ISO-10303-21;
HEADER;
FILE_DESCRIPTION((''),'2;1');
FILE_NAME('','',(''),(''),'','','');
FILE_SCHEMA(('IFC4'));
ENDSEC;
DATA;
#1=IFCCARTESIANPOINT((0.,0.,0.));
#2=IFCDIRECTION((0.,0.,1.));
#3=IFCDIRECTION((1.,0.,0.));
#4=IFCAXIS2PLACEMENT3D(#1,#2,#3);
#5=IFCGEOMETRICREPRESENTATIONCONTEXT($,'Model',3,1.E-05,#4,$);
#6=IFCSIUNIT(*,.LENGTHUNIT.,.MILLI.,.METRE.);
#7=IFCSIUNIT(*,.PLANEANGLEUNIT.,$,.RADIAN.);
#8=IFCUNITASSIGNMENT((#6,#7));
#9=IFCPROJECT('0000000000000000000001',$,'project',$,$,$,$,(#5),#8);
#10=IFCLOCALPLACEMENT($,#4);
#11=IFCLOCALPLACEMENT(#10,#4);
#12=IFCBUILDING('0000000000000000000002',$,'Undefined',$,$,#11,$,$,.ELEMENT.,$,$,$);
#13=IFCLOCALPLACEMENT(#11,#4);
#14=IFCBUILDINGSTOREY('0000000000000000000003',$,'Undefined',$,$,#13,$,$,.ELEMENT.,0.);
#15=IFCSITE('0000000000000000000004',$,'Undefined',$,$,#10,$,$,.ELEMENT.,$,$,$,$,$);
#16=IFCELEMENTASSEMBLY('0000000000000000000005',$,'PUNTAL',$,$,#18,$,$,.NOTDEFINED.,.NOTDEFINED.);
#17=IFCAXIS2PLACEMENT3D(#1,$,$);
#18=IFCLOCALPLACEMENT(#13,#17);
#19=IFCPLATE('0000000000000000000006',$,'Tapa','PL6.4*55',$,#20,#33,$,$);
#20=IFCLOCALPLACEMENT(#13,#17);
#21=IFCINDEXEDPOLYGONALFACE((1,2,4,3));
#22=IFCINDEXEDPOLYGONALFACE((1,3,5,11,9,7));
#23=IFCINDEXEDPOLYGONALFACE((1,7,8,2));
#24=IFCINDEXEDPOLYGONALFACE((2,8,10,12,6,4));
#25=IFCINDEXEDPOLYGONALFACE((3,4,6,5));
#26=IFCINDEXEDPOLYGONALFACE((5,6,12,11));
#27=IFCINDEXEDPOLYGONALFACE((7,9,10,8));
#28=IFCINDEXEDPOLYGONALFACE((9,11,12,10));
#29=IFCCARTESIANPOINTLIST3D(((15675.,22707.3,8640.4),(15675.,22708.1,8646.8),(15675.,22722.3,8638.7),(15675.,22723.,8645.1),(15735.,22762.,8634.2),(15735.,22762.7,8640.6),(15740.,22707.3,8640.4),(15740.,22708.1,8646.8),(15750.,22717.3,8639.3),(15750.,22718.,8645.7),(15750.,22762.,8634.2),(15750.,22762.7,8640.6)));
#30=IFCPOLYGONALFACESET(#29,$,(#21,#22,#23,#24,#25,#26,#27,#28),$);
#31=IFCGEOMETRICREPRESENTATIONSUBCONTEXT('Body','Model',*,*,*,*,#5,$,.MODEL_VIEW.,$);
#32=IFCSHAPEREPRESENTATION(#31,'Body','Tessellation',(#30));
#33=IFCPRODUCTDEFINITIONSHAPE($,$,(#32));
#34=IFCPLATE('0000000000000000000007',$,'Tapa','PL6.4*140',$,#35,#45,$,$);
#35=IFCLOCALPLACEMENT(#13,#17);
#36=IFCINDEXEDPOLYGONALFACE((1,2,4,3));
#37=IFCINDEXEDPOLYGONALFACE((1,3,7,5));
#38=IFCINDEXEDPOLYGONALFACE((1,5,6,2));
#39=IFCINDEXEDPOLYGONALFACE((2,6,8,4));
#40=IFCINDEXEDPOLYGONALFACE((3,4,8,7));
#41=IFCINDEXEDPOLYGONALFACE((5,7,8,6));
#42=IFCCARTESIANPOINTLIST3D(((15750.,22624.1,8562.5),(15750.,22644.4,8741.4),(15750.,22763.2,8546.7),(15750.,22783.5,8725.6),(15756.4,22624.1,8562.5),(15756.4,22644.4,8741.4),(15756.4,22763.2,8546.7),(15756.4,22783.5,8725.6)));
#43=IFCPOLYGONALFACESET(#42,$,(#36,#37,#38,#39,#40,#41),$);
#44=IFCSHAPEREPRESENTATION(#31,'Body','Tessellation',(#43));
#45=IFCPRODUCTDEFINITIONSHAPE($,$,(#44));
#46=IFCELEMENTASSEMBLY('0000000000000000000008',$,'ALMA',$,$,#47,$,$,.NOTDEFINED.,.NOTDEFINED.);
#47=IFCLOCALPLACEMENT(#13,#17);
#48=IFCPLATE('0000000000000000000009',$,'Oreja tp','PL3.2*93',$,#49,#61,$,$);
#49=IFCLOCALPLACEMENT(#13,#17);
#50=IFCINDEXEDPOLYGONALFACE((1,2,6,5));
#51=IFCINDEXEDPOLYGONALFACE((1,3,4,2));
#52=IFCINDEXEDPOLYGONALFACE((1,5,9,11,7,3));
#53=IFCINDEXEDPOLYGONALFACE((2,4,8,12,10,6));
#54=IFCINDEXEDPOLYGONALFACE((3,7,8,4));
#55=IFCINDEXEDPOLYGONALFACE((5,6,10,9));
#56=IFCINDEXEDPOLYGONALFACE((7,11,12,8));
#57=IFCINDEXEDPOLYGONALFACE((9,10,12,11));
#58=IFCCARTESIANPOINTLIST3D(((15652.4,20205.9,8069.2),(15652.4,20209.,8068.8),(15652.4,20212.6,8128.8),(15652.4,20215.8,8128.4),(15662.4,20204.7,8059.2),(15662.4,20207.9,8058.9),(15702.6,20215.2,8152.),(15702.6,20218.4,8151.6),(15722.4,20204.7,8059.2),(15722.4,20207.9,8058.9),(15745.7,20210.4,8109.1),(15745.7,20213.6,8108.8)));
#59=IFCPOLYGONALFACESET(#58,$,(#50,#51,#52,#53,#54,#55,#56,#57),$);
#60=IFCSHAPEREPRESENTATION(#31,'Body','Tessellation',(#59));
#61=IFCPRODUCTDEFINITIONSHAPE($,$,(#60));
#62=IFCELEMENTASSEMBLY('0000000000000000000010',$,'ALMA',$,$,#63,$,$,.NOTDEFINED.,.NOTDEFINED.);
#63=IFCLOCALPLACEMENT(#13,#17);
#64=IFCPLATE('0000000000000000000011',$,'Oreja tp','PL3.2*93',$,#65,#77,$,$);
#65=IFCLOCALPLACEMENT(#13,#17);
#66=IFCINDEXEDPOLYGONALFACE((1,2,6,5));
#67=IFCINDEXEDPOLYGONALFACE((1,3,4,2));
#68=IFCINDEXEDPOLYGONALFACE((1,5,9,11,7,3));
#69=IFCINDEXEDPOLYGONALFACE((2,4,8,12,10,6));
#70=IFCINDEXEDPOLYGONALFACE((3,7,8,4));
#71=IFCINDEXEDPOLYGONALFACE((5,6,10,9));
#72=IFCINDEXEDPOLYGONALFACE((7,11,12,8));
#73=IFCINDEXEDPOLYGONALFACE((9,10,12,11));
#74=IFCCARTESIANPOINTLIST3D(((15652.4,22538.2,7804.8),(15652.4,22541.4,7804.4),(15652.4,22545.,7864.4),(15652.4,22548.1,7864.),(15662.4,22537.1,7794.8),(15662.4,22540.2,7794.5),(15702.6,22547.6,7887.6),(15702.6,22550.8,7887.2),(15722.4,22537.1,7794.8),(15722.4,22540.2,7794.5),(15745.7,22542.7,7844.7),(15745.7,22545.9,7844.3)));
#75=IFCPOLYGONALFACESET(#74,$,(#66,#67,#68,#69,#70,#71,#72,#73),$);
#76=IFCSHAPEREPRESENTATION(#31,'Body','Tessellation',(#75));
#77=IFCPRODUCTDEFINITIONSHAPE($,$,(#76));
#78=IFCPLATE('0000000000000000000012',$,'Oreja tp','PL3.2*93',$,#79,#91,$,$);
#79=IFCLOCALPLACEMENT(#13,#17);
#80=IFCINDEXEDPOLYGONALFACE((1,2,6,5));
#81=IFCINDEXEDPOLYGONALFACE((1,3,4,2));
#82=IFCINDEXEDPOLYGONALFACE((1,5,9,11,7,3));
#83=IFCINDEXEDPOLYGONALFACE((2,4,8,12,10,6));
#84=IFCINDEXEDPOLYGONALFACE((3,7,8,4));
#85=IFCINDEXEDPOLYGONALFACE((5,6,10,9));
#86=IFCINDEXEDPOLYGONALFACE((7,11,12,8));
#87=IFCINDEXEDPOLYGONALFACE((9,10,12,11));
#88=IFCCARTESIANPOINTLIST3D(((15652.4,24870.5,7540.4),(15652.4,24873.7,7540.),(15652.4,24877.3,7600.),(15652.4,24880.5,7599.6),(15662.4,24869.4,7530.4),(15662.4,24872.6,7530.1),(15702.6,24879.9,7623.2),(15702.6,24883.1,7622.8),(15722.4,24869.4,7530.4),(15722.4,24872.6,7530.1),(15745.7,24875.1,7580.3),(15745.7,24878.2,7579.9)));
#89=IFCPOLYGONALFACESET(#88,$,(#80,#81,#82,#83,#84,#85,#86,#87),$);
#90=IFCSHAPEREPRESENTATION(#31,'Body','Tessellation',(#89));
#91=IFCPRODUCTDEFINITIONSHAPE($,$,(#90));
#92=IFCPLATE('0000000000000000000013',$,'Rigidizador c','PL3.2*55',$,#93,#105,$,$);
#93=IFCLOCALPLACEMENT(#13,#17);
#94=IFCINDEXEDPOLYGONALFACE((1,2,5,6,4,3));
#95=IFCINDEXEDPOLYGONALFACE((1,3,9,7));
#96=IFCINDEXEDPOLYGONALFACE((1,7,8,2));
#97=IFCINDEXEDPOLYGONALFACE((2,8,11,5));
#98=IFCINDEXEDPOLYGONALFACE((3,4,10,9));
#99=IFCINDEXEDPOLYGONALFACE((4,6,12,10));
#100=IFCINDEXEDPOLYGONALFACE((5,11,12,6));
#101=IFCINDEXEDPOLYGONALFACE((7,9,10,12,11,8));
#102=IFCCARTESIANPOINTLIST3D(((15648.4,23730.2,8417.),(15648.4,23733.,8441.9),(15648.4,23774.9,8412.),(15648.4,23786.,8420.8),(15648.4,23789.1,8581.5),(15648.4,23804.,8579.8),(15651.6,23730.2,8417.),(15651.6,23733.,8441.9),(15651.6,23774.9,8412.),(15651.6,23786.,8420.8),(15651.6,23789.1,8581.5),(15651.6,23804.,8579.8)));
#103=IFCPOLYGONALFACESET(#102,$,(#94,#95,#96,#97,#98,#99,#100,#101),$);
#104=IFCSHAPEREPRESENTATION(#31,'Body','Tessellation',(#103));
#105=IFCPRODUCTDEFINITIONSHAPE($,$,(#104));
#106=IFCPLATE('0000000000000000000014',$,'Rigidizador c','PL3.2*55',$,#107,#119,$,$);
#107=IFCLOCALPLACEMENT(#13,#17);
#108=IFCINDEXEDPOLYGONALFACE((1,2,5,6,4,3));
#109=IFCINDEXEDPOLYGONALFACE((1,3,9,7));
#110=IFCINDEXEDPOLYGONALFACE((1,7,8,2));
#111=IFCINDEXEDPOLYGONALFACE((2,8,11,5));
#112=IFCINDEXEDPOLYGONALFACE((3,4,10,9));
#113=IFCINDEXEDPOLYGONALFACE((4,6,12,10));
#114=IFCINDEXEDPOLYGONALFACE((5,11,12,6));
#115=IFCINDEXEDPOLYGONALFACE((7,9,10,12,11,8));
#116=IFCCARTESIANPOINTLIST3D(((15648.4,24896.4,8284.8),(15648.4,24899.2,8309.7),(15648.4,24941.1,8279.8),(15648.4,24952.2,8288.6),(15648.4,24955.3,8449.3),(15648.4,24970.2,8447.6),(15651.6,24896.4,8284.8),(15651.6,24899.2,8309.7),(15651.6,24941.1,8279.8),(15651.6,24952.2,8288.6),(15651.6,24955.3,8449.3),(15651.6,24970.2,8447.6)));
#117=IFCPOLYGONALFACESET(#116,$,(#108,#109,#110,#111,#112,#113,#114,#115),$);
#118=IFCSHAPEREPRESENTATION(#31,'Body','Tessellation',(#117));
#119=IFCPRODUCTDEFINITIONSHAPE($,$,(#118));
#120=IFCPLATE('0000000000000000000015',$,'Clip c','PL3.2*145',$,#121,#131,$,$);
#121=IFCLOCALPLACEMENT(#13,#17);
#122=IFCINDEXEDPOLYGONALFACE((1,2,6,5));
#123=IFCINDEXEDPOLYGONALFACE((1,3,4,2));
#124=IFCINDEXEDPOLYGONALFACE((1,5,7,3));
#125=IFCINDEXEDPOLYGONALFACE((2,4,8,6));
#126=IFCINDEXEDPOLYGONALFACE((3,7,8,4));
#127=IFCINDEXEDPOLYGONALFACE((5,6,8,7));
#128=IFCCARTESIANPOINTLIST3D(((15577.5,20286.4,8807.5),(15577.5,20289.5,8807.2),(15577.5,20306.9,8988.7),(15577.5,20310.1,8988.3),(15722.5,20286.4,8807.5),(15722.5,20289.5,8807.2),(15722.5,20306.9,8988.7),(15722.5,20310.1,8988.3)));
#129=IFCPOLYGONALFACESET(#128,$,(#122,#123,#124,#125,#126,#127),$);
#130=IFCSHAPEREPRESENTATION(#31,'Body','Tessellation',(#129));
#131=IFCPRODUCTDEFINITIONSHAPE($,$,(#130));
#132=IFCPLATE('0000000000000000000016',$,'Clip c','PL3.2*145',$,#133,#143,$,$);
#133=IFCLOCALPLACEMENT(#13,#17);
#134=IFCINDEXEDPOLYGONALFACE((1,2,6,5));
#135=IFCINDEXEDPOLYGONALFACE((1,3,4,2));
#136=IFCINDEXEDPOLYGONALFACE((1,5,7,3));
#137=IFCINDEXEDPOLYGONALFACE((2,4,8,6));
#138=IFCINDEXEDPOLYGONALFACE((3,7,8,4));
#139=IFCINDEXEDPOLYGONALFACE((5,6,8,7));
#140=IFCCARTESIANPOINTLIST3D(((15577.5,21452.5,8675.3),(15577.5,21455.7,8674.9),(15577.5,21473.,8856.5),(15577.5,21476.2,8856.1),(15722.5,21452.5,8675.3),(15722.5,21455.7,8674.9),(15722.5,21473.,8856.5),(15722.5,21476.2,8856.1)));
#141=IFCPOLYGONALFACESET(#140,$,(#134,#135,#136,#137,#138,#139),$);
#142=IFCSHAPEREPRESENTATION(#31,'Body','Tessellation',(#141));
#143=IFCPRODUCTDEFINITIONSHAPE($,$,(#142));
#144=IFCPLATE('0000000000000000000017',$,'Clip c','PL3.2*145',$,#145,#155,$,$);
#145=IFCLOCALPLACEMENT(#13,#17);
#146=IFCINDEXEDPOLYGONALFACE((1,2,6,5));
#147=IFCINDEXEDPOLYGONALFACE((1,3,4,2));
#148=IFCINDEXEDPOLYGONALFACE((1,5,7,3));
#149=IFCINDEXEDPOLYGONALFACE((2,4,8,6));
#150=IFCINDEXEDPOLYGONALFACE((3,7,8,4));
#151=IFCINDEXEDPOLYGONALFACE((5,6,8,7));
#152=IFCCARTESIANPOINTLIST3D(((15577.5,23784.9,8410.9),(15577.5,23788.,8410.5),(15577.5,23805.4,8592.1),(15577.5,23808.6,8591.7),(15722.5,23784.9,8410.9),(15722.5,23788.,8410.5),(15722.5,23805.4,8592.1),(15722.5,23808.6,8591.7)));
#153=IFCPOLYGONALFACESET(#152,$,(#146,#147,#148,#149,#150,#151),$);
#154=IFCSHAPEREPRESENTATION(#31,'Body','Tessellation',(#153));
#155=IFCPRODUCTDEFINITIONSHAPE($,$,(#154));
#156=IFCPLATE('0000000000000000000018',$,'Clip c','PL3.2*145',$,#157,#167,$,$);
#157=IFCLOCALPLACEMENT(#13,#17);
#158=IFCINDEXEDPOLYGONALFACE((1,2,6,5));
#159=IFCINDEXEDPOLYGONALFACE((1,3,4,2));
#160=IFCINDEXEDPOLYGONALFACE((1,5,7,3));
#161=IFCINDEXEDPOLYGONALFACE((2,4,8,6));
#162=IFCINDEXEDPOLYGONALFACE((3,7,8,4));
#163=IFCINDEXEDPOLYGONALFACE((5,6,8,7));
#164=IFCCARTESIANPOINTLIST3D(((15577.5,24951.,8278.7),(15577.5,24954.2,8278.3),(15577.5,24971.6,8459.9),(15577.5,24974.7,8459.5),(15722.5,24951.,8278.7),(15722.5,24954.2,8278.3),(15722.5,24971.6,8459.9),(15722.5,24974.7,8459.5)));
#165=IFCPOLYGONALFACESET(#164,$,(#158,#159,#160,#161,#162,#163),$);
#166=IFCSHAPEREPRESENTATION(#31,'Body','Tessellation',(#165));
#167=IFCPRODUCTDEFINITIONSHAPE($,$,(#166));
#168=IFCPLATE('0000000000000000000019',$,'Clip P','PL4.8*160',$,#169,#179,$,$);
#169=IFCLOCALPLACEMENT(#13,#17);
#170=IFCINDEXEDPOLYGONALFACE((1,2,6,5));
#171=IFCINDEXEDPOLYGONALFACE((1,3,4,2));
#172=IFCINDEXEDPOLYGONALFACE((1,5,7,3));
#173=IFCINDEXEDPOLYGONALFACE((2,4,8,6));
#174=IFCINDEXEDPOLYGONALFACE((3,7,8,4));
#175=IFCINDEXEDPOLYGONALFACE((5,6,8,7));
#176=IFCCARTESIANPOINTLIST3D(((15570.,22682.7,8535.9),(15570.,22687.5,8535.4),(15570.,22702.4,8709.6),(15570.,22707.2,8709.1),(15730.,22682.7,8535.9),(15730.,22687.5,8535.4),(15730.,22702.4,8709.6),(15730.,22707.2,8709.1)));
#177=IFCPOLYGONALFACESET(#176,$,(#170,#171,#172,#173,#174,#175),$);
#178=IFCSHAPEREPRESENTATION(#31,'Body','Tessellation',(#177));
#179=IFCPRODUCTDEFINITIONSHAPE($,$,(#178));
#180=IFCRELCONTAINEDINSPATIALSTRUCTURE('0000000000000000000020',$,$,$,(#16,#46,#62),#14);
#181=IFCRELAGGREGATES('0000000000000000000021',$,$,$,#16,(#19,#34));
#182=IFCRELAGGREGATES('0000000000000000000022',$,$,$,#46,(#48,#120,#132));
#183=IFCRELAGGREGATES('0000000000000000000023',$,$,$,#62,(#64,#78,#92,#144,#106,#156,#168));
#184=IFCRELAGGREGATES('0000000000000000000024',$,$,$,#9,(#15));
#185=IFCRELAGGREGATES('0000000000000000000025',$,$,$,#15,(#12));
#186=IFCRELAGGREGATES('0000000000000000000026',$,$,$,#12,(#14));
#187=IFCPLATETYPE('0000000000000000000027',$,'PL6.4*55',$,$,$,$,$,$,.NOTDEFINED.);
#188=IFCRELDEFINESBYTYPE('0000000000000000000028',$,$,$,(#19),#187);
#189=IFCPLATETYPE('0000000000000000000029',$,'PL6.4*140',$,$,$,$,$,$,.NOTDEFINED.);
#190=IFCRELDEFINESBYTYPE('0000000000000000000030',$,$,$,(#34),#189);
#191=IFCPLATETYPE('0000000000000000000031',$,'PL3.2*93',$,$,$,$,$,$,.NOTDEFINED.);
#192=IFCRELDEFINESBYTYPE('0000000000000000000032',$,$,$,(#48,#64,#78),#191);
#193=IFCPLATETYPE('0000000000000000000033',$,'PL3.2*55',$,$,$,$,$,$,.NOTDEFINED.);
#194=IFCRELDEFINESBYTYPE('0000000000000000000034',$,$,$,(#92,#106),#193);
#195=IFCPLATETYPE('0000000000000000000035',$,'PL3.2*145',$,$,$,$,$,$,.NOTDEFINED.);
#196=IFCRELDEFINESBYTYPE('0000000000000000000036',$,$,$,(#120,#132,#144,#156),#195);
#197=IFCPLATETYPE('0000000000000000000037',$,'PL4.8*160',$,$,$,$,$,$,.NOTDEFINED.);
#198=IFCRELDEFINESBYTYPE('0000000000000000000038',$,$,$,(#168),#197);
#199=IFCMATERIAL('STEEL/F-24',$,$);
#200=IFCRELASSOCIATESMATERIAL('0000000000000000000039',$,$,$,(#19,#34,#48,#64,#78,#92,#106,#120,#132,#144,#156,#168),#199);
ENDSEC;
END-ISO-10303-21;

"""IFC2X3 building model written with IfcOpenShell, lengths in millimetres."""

from ifc_helpers import new_model, si_unit, frame, origin_with_axes, place, context, subcontext, project, spatial, polyline, outline, extrude, material, type_object, element, aggregate, save


model = new_model("IFC2X3")

# Units and contexts
model_context = context("Model", 3, precision=1e-05, world=origin_with_axes())
body_context = subcontext(model_context, "Body", "Model", "MODEL_VIEW")
ifc_project = project(units=[si_unit("LENGTHUNIT", "METRE", prefix="MILLI"), si_unit("PLANEANGLEUNIT", "RADIAN")], contexts=[model_context])

# Site, building, storey
site_placement = place(None, origin_with_axes())
site = spatial("IfcSite", under=ifc_project, at=site_placement, Name="Undefined", CompositionType="ELEMENT")
building_placement = place(site_placement, origin_with_axes())
building = spatial("IfcBuilding", under=site, at=building_placement, Name="Undefined", CompositionType="ELEMENT")
storey_placement = place(building_placement, origin_with_axes())
storey = spatial("IfcBuildingStorey", under=building, at=storey_placement, Name="Undefined", CompositionType="ELEMENT", Elevation=0.0)

# Element assembly, plates
assembly_1_placement = place(storey_placement, origin_with_axes())
assembly_1 = element("IfcElementAssembly", 1, at=assembly_1_placement, inside=storey, Name="PUNTAL", AssemblyPlace="NOTDEFINED", PredefinedType="NOTDEFINED")
ifc_material_1 = material(Name="STEEL/F-24")
plate_type_1 = type_object("IfcPlateType", Name="PL6.4*55", PredefinedType="NOTDEFINED")
plate_1_placement = place(assembly_1_placement, frame((15675.0, 22707.7, 8643.6), z_axis=(0.0, 0.112644, 0.993635), x_axis=(1.0, 0.0, 0.0)))
plate_1 = element("IfcPlate", 2, at=plate_1_placement, type_object=plate_type_1, material=ifc_material_1, Name="Tapa", Description="PL6.4*55", context=body_context, shape_type="SweptSolid", body=[
    extrude(outline(polyline([(0.0, 0.0), (65.0, 0.0), (75.0, 10.0), (75.0, 55.0), (60.0, 55.0), (0.0, 15.0), (0.0, 0.0)])), frame((0.0, 0.0, -3.2), z_axis=(0.0, 0.0, 1.0), x_axis=(1.0, 0.0, 0.0)), (0.0, 0.0, 1.0), 6.4),
])
plate_type_2 = type_object("IfcPlateType", Name="PL6.4*140", PredefinedType="NOTDEFINED")
plate_2_placement = place(assembly_1_placement, frame((15753.2, 22783.5, 8725.6), z_axis=(1.0, 0.0, 0.0), x_axis=(0.0, -0.993635, 0.112644)))
plate_2 = element("IfcPlate", 3, at=plate_2_placement, type_object=plate_type_2, material=ifc_material_1, Name="Tapa", Description="PL6.4*140", context=body_context, shape_type="SweptSolid", body=[
    extrude(outline(polyline([(0.0, 0.0), (140.0, 0.0), (140.0, 180.0), (0.0, 180.0), (0.0, 0.0)])), frame((0.0, 0.0, -3.2), z_axis=(0.0, 0.0, 1.0), x_axis=(1.0, 0.0, 0.0)), (0.0, 0.0, 1.0), 6.4),
])
aggregate(assembly_1, [plate_1, plate_2])

# Element assembly, plate
assembly_2_placement = place(storey_placement, origin_with_axes())
assembly_2 = element("IfcElementAssembly", 4, at=assembly_2_placement, inside=storey, Name="ALMA", AssemblyPlace="NOTDEFINED", PredefinedType="NOTDEFINED")
plate_type_3 = type_object("IfcPlateType", Name="PL3.2*93", PredefinedType="NOTDEFINED")
plate_3_placement = place(assembly_2_placement, frame((15722.4, 20206.3, 8059.1), z_axis=(0.0, 0.993635, -0.112644), x_axis=(-1.0, -0.000004, -0.000037)))
plate_3 = element("IfcPlate", 5, at=plate_3_placement, type_object=plate_type_3, material=ifc_material_1, Name="Oreja tp", Description="PL3.2*93", context=body_context, shape_type="SweptSolid", body=[
    extrude(outline(polyline([(0.0, 0.0), (60.0, 0.0), (70.0, 10.0), (70.0, 70.0), (19.8, 93.3), (-23.3, 50.2), (0.0, 0.0)])), frame((0.0, 0.0, -1.6), z_axis=(0.0, 0.0, 1.0), x_axis=(1.0, 0.0, 0.0)), (0.0, 0.0, 1.0), 3.2),
])

# Element assembly, plates
assembly_3_placement = place(storey_placement, origin_with_axes())
assembly_3 = element("IfcElementAssembly", 6, at=assembly_3_placement, inside=storey, Name="ALMA", AssemblyPlace="NOTDEFINED", PredefinedType="NOTDEFINED")
plate_4_placement = place(assembly_3_placement, frame((15722.4, 22538.7, 7794.7), z_axis=(0.0, 0.993635, -0.112644), x_axis=(-1.0, -0.000004, -0.000037)))
plate_4 = element("IfcPlate", 7, at=plate_4_placement, type_object=plate_type_3, material=ifc_material_1, Name="Oreja tp", Description="PL3.2*93", context=body_context, shape_type="SweptSolid", body=[
    extrude(outline(polyline([(0.0, 0.0), (60.0, 0.0), (70.0, 10.0), (70.0, 70.0), (19.8, 93.3), (-23.3, 50.2), (0.0, 0.0)])), frame((0.0, 0.0, -1.6), z_axis=(0.0, 0.0, 1.0), x_axis=(1.0, 0.0, 0.0)), (0.0, 0.0, 1.0), 3.2),
])
plate_5_placement = place(assembly_3_placement, frame((15722.4, 24871.0, 7530.3), z_axis=(0.0, 0.993635, -0.112644), x_axis=(-1.0, -0.000004, -0.000037)))
plate_5 = element("IfcPlate", 8, at=plate_5_placement, type_object=plate_type_3, material=ifc_material_1, Name="Oreja tp", Description="PL3.2*93", context=body_context, shape_type="SweptSolid", body=[
    extrude(outline(polyline([(0.0, 0.0), (60.0, 0.0), (70.0, 10.0), (70.0, 70.0), (19.8, 93.3), (-23.3, 50.2), (0.0, 0.0)])), frame((0.0, 0.0, -1.6), z_axis=(0.0, 0.0, 1.0), x_axis=(1.0, 0.0, 0.0)), (0.0, 0.0, 1.0), 3.2),
])
plate_type_4 = type_object("IfcPlateType", Name="PL3.2*55", PredefinedType="NOTDEFINED")
plate_6_placement = place(assembly_3_placement, frame((15650.0, 23804.0, 8579.8), z_axis=(1.0, 0.0, 0.0), x_axis=(0.0, -0.993635, 0.112644)))
plate_6 = element("IfcPlate", 9, at=plate_6_placement, type_object=plate_type_4, material=ifc_material_1, Name="Rigidizador c", Description="PL3.2*55", context=body_context, shape_type="SweptSolid", body=[
    extrude(outline(polyline([(0.0, 0.0), (15.0, 0.0), (55.0, 145.0), (55.0, 170.1), (10.0, 170.0), (0.0, 160.0), (0.0, 0.0)])), frame((0.0, 0.0, -1.6), z_axis=(0.0, 0.0, 1.0), x_axis=(1.0, 0.0, 0.0)), (0.0, 0.0, 1.0), 3.2),
])
plate_7_placement = place(assembly_3_placement, frame((15650.0, 24970.2, 8447.6), z_axis=(1.0, 0.0, 0.0), x_axis=(0.0, -0.993635, 0.112644)))
plate_7 = element("IfcPlate", 10, at=plate_7_placement, type_object=plate_type_4, material=ifc_material_1, Name="Rigidizador c", Description="PL3.2*55", context=body_context, shape_type="SweptSolid", body=[
    extrude(outline(polyline([(0.0, 0.0), (15.0, 0.0), (55.0, 145.0), (55.0, 170.1), (10.0, 170.0), (0.0, 160.0), (0.0, 0.0)])), frame((0.0, 0.0, -1.6), z_axis=(0.0, 0.0, 1.0), x_axis=(1.0, 0.0, 0.0)), (0.0, 0.0, 1.0), 3.2),
])

# Plates
plate_type_5 = type_object("IfcPlateType", Name="PL3.2*145", PredefinedType="NOTDEFINED")
plate_8_placement = place(assembly_2_placement, frame((15722.5, 20287.9, 8807.3), z_axis=(0.0, -0.993645, 0.112559), x_axis=(0.0, 0.112559, 0.993645)))
plate_8 = element("IfcPlate", 11, at=plate_8_placement, type_object=plate_type_5, material=ifc_material_1, Name="Clip c", Description="PL3.2*145", context=body_context, shape_type="SweptSolid", body=[
    extrude(outline(polyline([(0.0, 0.0), (182.3, 0.0), (182.3, 145.0), (0.0, 145.0), (0.0, 0.0)])), frame((0.0, 0.0, -1.6), z_axis=(0.0, 0.0, 1.0), x_axis=(1.0, 0.0, 0.0)), (0.0, 0.0, 1.0), 3.2),
])
plate_9_placement = place(assembly_2_placement, frame((15722.5, 21454.1, 8675.1), z_axis=(0.0, -0.993645, 0.112559), x_axis=(0.0, 0.112559, 0.993645)))
plate_9 = element("IfcPlate", 12, at=plate_9_placement, type_object=plate_type_5, material=ifc_material_1, Name="Clip c", Description="PL3.2*145", context=body_context, shape_type="SweptSolid", body=[
    extrude(outline(polyline([(0.0, 0.0), (182.3, 0.0), (182.3, 145.0), (0.0, 145.0), (0.0, 0.0)])), frame((0.0, 0.0, -1.6), z_axis=(0.0, 0.0, 1.0), x_axis=(1.0, 0.0, 0.0)), (0.0, 0.0, 1.0), 3.2),
])
plate_10_placement = place(assembly_3_placement, frame((15722.5, 23786.4, 8410.7), z_axis=(0.0, -0.993645, 0.112559), x_axis=(0.0, 0.112559, 0.993645)))
plate_10 = element("IfcPlate", 13, at=plate_10_placement, type_object=plate_type_5, material=ifc_material_1, Name="Clip c", Description="PL3.2*145", context=body_context, shape_type="SweptSolid", body=[
    extrude(outline(polyline([(0.0, 0.0), (182.3, 0.0), (182.3, 145.0), (0.0, 145.0), (0.0, 0.0)])), frame((0.0, 0.0, -1.6), z_axis=(0.0, 0.0, 1.0), x_axis=(1.0, 0.0, 0.0)), (0.0, 0.0, 1.0), 3.2),
])
plate_11_placement = place(assembly_3_placement, frame((15722.5, 24952.6, 8278.5), z_axis=(0.0, -0.993645, 0.112559), x_axis=(0.0, 0.112559, 0.993645)))
plate_11 = element("IfcPlate", 14, at=plate_11_placement, type_object=plate_type_5, material=ifc_material_1, Name="Clip c", Description="PL3.2*145", context=body_context, shape_type="SweptSolid", body=[
    extrude(outline(polyline([(0.0, 0.0), (182.3, 0.0), (182.3, 145.0), (0.0, 145.0), (0.0, 0.0)])), frame((0.0, 0.0, -1.6), z_axis=(0.0, 0.0, 1.0), x_axis=(1.0, 0.0, 0.0)), (0.0, 0.0, 1.0), 3.2),
])
plate_type_6 = type_object("IfcPlateType", Name="PL4.8*160", PredefinedType="NOTDEFINED")
plate_12_placement = place(assembly_3_placement, frame((15730.0, 22685.1, 8535.6), z_axis=(0.0, -0.993645, 0.112555), x_axis=(0.0, 0.112555, 0.993645)))
plate_12 = element("IfcPlate", 15, at=plate_12_placement, type_object=plate_type_6, material=ifc_material_1, Name="Clip P", Description="PL4.8*160", context=body_context, shape_type="SweptSolid", body=[
    extrude(outline(polyline([(0.0, 0.0), (174.8, 0.0), (174.8, 160.0), (0.0, 160.0), (0.0, 0.0)])), frame((0.0, 0.0, -2.4), z_axis=(0.0, 0.0, 1.0), x_axis=(1.0, 0.0, 0.0)), (0.0, 0.0, 1.0), 4.8),
])

aggregate(assembly_2, [plate_3, plate_8, plate_9])

aggregate(assembly_3, [plate_4, plate_5, plate_6, plate_10, plate_7, plate_11, plate_12])

save(model, "model.ifc")
